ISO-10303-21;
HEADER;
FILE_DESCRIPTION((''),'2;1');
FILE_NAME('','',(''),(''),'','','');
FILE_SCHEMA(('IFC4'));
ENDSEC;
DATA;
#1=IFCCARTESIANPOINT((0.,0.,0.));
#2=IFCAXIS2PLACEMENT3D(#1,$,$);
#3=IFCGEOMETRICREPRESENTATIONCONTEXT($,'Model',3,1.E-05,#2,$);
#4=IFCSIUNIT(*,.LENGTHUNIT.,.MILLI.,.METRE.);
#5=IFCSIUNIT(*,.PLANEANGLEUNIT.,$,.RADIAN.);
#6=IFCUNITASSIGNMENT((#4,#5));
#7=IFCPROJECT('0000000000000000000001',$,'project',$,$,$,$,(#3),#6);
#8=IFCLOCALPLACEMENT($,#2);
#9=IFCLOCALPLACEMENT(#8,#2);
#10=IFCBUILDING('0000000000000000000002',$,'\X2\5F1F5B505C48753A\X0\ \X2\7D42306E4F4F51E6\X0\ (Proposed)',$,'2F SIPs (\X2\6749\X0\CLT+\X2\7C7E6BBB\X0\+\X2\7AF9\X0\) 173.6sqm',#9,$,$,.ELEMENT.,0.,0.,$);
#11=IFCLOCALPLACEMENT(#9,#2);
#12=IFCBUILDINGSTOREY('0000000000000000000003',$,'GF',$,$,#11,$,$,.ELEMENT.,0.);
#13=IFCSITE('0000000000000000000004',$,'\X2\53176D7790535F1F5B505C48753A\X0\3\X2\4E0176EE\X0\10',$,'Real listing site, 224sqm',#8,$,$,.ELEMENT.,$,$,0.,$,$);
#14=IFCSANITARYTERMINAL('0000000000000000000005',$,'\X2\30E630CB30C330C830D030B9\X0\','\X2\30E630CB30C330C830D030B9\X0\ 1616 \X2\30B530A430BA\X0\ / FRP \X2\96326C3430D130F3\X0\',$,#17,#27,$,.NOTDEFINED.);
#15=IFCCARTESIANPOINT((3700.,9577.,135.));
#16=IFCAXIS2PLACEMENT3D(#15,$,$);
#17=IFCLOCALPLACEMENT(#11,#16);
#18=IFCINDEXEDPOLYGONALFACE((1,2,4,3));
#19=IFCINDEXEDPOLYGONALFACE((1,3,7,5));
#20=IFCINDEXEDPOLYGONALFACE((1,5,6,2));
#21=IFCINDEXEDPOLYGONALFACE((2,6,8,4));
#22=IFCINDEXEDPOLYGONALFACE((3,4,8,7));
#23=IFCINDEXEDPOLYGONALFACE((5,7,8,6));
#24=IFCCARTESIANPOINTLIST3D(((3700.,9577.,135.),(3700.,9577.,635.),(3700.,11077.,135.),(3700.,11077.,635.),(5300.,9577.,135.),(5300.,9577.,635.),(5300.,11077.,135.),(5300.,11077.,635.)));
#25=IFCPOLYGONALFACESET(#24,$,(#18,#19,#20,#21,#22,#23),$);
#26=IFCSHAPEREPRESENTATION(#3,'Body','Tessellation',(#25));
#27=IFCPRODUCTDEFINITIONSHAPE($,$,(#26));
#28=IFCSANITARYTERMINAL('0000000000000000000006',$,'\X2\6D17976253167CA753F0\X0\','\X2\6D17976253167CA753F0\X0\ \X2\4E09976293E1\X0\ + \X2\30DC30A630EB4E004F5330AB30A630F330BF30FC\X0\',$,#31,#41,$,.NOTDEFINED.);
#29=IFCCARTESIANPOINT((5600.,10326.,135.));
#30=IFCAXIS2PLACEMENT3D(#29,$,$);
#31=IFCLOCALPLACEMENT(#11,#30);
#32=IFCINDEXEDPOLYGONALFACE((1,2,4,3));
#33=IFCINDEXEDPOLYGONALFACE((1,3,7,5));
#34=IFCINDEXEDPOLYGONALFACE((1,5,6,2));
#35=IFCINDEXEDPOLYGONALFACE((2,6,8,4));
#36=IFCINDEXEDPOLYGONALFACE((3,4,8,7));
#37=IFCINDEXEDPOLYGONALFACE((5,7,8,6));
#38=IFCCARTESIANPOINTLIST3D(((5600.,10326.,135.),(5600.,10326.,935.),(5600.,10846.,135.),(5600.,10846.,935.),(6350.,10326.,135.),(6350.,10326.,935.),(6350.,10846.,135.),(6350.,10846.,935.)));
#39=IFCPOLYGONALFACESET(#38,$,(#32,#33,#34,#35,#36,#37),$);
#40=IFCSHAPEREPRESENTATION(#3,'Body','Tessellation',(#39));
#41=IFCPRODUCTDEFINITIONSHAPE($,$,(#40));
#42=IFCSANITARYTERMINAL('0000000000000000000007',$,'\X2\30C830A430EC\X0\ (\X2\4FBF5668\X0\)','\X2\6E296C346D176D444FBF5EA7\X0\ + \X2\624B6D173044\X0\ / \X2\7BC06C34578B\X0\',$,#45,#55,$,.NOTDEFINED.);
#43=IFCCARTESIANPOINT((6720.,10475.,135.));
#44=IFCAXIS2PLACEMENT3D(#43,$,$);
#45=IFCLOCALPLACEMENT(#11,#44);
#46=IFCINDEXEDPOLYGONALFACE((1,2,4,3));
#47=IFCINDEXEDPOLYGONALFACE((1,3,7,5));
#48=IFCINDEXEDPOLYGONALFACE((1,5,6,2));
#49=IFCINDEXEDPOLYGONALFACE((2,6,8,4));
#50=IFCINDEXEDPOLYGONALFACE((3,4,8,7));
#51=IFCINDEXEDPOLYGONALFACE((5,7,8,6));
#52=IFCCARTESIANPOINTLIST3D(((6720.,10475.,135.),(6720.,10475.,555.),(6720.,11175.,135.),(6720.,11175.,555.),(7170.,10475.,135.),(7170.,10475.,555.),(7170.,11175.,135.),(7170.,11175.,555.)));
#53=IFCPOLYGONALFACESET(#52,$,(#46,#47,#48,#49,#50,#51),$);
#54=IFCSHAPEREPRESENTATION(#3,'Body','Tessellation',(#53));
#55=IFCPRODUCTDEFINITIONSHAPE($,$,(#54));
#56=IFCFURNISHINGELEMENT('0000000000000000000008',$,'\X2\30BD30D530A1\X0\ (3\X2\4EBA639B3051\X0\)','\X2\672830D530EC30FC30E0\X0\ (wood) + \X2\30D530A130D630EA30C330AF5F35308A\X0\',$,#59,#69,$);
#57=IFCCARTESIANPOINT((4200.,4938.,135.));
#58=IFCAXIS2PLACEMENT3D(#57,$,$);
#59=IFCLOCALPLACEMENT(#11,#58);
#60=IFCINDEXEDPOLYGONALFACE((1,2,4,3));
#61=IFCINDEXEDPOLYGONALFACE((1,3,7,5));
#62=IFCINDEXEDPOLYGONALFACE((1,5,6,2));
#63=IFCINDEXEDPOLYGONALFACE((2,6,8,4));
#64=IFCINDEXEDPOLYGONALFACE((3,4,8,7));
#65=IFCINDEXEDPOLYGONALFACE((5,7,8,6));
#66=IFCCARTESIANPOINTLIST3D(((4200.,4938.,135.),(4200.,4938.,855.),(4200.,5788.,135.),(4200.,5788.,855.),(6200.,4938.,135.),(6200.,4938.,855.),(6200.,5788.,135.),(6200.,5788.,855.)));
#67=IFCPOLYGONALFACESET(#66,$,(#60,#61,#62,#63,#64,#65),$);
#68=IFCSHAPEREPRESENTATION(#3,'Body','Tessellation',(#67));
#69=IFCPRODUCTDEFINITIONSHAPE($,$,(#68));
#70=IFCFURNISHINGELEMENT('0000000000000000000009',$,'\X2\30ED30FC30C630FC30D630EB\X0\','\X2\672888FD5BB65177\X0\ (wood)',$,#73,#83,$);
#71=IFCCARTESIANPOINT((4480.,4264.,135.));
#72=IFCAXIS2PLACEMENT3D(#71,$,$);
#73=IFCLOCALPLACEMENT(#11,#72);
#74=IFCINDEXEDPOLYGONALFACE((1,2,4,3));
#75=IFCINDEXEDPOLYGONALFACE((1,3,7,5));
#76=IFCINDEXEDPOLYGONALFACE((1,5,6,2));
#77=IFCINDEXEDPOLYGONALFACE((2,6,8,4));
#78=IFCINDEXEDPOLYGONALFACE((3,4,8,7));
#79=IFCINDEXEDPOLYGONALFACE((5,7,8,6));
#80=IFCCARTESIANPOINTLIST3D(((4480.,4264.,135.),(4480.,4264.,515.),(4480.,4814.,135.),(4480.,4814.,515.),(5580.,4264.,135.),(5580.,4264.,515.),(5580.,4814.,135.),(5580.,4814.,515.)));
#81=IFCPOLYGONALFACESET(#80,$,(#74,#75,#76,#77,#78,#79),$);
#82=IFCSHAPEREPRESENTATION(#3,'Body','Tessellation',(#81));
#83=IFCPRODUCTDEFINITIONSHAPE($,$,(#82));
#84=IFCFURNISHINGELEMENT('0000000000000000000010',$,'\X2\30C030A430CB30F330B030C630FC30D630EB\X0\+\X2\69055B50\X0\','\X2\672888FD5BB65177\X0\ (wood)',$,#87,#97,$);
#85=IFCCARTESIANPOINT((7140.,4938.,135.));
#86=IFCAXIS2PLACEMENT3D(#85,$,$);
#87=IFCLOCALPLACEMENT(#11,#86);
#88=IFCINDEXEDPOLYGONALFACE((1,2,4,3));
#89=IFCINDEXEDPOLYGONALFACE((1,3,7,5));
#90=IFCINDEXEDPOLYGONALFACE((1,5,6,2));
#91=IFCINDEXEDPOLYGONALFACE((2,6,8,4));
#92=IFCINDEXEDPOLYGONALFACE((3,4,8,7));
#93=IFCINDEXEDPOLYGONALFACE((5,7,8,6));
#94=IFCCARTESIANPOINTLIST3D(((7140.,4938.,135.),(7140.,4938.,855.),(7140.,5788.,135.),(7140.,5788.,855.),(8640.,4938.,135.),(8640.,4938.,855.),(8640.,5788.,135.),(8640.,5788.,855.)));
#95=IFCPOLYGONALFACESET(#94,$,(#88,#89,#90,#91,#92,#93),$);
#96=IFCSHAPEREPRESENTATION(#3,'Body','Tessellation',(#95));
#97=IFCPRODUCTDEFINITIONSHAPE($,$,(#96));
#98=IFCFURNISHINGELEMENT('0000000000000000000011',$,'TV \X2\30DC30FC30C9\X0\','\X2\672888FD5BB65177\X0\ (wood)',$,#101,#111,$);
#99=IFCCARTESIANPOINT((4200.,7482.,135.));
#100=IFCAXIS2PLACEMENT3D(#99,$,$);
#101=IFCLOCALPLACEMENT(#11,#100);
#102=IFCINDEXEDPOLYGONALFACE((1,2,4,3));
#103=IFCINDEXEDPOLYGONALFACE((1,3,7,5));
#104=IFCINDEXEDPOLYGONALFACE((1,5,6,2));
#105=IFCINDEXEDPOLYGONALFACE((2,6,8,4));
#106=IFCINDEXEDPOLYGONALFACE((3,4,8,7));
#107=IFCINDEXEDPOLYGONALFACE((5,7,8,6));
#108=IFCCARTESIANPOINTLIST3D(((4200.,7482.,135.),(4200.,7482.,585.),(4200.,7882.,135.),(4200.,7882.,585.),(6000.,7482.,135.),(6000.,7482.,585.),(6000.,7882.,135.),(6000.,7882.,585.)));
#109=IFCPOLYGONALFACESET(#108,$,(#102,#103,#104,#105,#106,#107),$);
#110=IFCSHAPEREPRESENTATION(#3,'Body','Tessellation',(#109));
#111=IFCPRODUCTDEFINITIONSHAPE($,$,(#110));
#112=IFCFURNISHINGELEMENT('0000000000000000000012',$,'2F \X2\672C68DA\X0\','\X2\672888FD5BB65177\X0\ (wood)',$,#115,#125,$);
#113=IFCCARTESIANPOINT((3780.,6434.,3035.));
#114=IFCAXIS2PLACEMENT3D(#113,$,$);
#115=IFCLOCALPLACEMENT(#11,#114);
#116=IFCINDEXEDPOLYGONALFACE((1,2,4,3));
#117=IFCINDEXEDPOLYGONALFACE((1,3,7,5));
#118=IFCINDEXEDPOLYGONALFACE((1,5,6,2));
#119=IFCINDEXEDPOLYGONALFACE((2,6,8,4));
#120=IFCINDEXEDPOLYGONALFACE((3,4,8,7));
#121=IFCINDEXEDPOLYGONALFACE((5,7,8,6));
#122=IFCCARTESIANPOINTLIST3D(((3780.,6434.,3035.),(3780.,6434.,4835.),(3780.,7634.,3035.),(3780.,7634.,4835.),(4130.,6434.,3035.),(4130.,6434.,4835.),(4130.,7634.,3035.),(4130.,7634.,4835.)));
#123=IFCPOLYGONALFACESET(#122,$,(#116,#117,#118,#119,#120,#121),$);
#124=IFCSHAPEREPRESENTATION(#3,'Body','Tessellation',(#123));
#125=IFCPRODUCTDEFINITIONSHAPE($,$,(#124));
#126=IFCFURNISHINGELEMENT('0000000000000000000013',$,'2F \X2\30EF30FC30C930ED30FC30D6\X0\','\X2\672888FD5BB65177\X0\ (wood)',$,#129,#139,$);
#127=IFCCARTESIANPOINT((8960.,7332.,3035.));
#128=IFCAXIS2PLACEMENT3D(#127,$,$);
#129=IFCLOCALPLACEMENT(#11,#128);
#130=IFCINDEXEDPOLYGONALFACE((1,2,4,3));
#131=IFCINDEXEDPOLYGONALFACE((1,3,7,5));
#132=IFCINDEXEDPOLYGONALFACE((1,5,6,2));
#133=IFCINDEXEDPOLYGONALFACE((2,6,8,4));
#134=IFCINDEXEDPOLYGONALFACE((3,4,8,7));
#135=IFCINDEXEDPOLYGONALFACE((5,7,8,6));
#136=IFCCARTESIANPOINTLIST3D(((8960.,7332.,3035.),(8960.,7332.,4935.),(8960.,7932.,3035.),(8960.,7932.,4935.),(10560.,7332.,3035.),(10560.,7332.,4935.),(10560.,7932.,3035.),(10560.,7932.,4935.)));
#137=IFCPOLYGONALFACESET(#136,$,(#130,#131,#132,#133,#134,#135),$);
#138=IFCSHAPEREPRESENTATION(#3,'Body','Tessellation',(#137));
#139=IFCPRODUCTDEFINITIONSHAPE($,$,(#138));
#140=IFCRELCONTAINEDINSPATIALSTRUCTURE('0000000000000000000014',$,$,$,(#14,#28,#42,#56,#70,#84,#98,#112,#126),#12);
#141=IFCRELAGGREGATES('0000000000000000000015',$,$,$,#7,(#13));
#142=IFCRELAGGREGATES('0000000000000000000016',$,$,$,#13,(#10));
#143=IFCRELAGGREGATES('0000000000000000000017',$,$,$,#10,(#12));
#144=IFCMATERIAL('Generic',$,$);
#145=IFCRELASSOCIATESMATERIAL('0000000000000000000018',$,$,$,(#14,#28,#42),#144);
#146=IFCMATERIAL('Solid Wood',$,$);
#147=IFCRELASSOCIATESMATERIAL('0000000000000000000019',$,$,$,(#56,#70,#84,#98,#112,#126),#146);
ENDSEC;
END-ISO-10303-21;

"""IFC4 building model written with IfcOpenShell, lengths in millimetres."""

from ifc_helpers import new_model, si_unit, frame, frame_2d, origin, place, context, project, spatial, rectangle, extrude, material, element, save


model = new_model("IFC4")

# Units and contexts
model_context = context("Model", 3, precision=1e-05, world=origin())
ifc_project = project(units=[si_unit("LENGTHUNIT", "METRE", prefix="MILLI"), si_unit("PLANEANGLEUNIT", "RADIAN")], contexts=[model_context])

# Site, building, storey
site_placement = place(None, origin())
site = spatial("IfcSite", under=ifc_project, at=site_placement, Name="北海道弟子屈町3丁目10", ObjectType="Real listing site, 224sqm", CompositionType="ELEMENT", RefElevation=0.0)
building_placement = place(site_placement, origin())
building = spatial("IfcBuilding", under=site, at=building_placement, Name="弟子屈町 終の住処 (Proposed)", ObjectType="2F SIPs (杉CLT+籾殻+竹) 173.6sqm", CompositionType="ELEMENT", ElevationOfRefHeight=0.0, ElevationOfTerrain=0.0)
storey_placement = place(building_placement, origin())
storey = spatial("IfcBuildingStorey", under=building, at=storey_placement, Name="GF", CompositionType="ELEMENT", Elevation=0.0)

# Shared definitions
ifc_material_1 = material(Name="Generic")

# Shared definitions
ifc_material_2 = material(Name="Solid Wood")

# Sanitary terminals
sanitary_terminal_1_placement = place(storey_placement, frame((3700.0, 9577.0, 135.0)))
element("IfcSanitaryTerminal", 1, at=sanitary_terminal_1_placement, inside=storey, material=ifc_material_1, Name="ユニットバス", Description="ユニットバス 1616 サイズ / FRP 防水パン", PredefinedType="NOTDEFINED", context=model_context, shape_type="SweptSolid", body=[
    extrude(rectangle(XDim=1600.0, YDim=1500.0, at=frame_2d((800.0, 750.0))), frame((3700.0, 9577.0, 135.0)), (0.0, 0.0, 1.0), 500.0),
])
sanitary_terminal_2_placement = place(storey_placement, frame((5600.0, 10326.0, 135.0)))
element("IfcSanitaryTerminal", 2, at=sanitary_terminal_2_placement, inside=storey, material=ifc_material_1, Name="洗面化粧台", Description="洗面化粧台 三面鏡 + ボウル一体カウンター", PredefinedType="NOTDEFINED", context=model_context, shape_type="SweptSolid", body=[
    extrude(rectangle(XDim=750.0, YDim=520.0, at=frame_2d((375.0, 260.0))), frame((5600.0, 10326.0, 135.0)), (0.0, 0.0, 1.0), 800.0),
])
sanitary_terminal_3_placement = place(storey_placement, frame((6720.0, 10475.0, 135.0)))
element("IfcSanitaryTerminal", 3, at=sanitary_terminal_3_placement, inside=storey, material=ifc_material_1, Name="トイレ (便器)", Description="温水洗浄便座 + 手洗い / 節水型", PredefinedType="NOTDEFINED", context=model_context, shape_type="SweptSolid", body=[
    extrude(rectangle(XDim=450.0, YDim=700.0, at=frame_2d((225.0, 350.0))), frame((6720.0, 10475.0, 135.0)), (0.0, 0.0, 1.0), 420.0),
])

# Furnishing elements
furnishing_1_placement = place(storey_placement, frame((4200.0, 4938.0, 135.0)))
element("IfcFurnishingElement", 4, at=furnishing_1_placement, inside=storey, material=ifc_material_2, Name="ソファ (3人掛け)", Description="木フレーム (wood) + ファブリック張り", context=model_context, shape_type="SweptSolid", body=[
    extrude(rectangle(XDim=2000.0, YDim=850.0, at=frame_2d((1000.0, 425.0))), frame((4200.0, 4938.0, 135.0)), (0.0, 0.0, 1.0), 720.0),
])
furnishing_2_placement = place(storey_placement, frame((4480.0, 4264.0, 135.0)))
element("IfcFurnishingElement", 5, at=furnishing_2_placement, inside=storey, material=ifc_material_2, Name="ローテーブル", Description="木製家具 (wood)", context=model_context, shape_type="SweptSolid", body=[
    extrude(rectangle(XDim=1100.0, YDim=550.0, at=frame_2d((550.0, 275.0))), frame((4480.0, 4264.0, 135.0)), (0.0, 0.0, 1.0), 380.0),
])
furnishing_3_placement = place(storey_placement, frame((7140.0, 4938.0, 135.0)))
element("IfcFurnishingElement", 6, at=furnishing_3_placement, inside=storey, material=ifc_material_2, Name="ダイニングテーブル+椅子", Description="木製家具 (wood)", context=model_context, shape_type="SweptSolid", body=[
    extrude(rectangle(XDim=1500.0, YDim=850.0, at=frame_2d((750.0, 425.0))), frame((7140.0, 4938.0, 135.0)), (0.0, 0.0, 1.0), 720.0),
])
furnishing_4_placement = place(storey_placement, frame((4200.0, 7482.0, 135.0)))
element("IfcFurnishingElement", 7, at=furnishing_4_placement, inside=storey, material=ifc_material_2, Name="TV ボード", Description="木製家具 (wood)", context=model_context, shape_type="SweptSolid", body=[
    extrude(rectangle(XDim=1800.0, YDim=400.0, at=frame_2d((900.0, 200.0))), frame((4200.0, 7482.0, 135.0)), (0.0, 0.0, 1.0), 450.0),
])
furnishing_5_placement = place(storey_placement, frame((3780.0, 6434.0, 3035.0)))
element("IfcFurnishingElement", 8, at=furnishing_5_placement, inside=storey, material=ifc_material_2, Name="2F 本棚", Description="木製家具 (wood)", context=model_context, shape_type="SweptSolid", body=[
    extrude(rectangle(XDim=350.0, YDim=1200.0, at=frame_2d((175.0, 600.0))), frame((3780.0, 6434.0, 3035.0)), (0.0, 0.0, 1.0), 1800.0),
])
furnishing_6_placement = place(storey_placement, frame((8960.0, 7332.0, 3035.0)))
element("IfcFurnishingElement", 9, at=furnishing_6_placement, inside=storey, material=ifc_material_2, Name="2F ワードローブ", Description="木製家具 (wood)", context=model_context, shape_type="SweptSolid", body=[
    extrude(rectangle(XDim=1600.0, YDim=600.0, at=frame_2d((800.0, 300.0))), frame((8960.0, 7332.0, 3035.0)), (0.0, 0.0, 1.0), 1900.0),
])

save(model, "model.ifc")
